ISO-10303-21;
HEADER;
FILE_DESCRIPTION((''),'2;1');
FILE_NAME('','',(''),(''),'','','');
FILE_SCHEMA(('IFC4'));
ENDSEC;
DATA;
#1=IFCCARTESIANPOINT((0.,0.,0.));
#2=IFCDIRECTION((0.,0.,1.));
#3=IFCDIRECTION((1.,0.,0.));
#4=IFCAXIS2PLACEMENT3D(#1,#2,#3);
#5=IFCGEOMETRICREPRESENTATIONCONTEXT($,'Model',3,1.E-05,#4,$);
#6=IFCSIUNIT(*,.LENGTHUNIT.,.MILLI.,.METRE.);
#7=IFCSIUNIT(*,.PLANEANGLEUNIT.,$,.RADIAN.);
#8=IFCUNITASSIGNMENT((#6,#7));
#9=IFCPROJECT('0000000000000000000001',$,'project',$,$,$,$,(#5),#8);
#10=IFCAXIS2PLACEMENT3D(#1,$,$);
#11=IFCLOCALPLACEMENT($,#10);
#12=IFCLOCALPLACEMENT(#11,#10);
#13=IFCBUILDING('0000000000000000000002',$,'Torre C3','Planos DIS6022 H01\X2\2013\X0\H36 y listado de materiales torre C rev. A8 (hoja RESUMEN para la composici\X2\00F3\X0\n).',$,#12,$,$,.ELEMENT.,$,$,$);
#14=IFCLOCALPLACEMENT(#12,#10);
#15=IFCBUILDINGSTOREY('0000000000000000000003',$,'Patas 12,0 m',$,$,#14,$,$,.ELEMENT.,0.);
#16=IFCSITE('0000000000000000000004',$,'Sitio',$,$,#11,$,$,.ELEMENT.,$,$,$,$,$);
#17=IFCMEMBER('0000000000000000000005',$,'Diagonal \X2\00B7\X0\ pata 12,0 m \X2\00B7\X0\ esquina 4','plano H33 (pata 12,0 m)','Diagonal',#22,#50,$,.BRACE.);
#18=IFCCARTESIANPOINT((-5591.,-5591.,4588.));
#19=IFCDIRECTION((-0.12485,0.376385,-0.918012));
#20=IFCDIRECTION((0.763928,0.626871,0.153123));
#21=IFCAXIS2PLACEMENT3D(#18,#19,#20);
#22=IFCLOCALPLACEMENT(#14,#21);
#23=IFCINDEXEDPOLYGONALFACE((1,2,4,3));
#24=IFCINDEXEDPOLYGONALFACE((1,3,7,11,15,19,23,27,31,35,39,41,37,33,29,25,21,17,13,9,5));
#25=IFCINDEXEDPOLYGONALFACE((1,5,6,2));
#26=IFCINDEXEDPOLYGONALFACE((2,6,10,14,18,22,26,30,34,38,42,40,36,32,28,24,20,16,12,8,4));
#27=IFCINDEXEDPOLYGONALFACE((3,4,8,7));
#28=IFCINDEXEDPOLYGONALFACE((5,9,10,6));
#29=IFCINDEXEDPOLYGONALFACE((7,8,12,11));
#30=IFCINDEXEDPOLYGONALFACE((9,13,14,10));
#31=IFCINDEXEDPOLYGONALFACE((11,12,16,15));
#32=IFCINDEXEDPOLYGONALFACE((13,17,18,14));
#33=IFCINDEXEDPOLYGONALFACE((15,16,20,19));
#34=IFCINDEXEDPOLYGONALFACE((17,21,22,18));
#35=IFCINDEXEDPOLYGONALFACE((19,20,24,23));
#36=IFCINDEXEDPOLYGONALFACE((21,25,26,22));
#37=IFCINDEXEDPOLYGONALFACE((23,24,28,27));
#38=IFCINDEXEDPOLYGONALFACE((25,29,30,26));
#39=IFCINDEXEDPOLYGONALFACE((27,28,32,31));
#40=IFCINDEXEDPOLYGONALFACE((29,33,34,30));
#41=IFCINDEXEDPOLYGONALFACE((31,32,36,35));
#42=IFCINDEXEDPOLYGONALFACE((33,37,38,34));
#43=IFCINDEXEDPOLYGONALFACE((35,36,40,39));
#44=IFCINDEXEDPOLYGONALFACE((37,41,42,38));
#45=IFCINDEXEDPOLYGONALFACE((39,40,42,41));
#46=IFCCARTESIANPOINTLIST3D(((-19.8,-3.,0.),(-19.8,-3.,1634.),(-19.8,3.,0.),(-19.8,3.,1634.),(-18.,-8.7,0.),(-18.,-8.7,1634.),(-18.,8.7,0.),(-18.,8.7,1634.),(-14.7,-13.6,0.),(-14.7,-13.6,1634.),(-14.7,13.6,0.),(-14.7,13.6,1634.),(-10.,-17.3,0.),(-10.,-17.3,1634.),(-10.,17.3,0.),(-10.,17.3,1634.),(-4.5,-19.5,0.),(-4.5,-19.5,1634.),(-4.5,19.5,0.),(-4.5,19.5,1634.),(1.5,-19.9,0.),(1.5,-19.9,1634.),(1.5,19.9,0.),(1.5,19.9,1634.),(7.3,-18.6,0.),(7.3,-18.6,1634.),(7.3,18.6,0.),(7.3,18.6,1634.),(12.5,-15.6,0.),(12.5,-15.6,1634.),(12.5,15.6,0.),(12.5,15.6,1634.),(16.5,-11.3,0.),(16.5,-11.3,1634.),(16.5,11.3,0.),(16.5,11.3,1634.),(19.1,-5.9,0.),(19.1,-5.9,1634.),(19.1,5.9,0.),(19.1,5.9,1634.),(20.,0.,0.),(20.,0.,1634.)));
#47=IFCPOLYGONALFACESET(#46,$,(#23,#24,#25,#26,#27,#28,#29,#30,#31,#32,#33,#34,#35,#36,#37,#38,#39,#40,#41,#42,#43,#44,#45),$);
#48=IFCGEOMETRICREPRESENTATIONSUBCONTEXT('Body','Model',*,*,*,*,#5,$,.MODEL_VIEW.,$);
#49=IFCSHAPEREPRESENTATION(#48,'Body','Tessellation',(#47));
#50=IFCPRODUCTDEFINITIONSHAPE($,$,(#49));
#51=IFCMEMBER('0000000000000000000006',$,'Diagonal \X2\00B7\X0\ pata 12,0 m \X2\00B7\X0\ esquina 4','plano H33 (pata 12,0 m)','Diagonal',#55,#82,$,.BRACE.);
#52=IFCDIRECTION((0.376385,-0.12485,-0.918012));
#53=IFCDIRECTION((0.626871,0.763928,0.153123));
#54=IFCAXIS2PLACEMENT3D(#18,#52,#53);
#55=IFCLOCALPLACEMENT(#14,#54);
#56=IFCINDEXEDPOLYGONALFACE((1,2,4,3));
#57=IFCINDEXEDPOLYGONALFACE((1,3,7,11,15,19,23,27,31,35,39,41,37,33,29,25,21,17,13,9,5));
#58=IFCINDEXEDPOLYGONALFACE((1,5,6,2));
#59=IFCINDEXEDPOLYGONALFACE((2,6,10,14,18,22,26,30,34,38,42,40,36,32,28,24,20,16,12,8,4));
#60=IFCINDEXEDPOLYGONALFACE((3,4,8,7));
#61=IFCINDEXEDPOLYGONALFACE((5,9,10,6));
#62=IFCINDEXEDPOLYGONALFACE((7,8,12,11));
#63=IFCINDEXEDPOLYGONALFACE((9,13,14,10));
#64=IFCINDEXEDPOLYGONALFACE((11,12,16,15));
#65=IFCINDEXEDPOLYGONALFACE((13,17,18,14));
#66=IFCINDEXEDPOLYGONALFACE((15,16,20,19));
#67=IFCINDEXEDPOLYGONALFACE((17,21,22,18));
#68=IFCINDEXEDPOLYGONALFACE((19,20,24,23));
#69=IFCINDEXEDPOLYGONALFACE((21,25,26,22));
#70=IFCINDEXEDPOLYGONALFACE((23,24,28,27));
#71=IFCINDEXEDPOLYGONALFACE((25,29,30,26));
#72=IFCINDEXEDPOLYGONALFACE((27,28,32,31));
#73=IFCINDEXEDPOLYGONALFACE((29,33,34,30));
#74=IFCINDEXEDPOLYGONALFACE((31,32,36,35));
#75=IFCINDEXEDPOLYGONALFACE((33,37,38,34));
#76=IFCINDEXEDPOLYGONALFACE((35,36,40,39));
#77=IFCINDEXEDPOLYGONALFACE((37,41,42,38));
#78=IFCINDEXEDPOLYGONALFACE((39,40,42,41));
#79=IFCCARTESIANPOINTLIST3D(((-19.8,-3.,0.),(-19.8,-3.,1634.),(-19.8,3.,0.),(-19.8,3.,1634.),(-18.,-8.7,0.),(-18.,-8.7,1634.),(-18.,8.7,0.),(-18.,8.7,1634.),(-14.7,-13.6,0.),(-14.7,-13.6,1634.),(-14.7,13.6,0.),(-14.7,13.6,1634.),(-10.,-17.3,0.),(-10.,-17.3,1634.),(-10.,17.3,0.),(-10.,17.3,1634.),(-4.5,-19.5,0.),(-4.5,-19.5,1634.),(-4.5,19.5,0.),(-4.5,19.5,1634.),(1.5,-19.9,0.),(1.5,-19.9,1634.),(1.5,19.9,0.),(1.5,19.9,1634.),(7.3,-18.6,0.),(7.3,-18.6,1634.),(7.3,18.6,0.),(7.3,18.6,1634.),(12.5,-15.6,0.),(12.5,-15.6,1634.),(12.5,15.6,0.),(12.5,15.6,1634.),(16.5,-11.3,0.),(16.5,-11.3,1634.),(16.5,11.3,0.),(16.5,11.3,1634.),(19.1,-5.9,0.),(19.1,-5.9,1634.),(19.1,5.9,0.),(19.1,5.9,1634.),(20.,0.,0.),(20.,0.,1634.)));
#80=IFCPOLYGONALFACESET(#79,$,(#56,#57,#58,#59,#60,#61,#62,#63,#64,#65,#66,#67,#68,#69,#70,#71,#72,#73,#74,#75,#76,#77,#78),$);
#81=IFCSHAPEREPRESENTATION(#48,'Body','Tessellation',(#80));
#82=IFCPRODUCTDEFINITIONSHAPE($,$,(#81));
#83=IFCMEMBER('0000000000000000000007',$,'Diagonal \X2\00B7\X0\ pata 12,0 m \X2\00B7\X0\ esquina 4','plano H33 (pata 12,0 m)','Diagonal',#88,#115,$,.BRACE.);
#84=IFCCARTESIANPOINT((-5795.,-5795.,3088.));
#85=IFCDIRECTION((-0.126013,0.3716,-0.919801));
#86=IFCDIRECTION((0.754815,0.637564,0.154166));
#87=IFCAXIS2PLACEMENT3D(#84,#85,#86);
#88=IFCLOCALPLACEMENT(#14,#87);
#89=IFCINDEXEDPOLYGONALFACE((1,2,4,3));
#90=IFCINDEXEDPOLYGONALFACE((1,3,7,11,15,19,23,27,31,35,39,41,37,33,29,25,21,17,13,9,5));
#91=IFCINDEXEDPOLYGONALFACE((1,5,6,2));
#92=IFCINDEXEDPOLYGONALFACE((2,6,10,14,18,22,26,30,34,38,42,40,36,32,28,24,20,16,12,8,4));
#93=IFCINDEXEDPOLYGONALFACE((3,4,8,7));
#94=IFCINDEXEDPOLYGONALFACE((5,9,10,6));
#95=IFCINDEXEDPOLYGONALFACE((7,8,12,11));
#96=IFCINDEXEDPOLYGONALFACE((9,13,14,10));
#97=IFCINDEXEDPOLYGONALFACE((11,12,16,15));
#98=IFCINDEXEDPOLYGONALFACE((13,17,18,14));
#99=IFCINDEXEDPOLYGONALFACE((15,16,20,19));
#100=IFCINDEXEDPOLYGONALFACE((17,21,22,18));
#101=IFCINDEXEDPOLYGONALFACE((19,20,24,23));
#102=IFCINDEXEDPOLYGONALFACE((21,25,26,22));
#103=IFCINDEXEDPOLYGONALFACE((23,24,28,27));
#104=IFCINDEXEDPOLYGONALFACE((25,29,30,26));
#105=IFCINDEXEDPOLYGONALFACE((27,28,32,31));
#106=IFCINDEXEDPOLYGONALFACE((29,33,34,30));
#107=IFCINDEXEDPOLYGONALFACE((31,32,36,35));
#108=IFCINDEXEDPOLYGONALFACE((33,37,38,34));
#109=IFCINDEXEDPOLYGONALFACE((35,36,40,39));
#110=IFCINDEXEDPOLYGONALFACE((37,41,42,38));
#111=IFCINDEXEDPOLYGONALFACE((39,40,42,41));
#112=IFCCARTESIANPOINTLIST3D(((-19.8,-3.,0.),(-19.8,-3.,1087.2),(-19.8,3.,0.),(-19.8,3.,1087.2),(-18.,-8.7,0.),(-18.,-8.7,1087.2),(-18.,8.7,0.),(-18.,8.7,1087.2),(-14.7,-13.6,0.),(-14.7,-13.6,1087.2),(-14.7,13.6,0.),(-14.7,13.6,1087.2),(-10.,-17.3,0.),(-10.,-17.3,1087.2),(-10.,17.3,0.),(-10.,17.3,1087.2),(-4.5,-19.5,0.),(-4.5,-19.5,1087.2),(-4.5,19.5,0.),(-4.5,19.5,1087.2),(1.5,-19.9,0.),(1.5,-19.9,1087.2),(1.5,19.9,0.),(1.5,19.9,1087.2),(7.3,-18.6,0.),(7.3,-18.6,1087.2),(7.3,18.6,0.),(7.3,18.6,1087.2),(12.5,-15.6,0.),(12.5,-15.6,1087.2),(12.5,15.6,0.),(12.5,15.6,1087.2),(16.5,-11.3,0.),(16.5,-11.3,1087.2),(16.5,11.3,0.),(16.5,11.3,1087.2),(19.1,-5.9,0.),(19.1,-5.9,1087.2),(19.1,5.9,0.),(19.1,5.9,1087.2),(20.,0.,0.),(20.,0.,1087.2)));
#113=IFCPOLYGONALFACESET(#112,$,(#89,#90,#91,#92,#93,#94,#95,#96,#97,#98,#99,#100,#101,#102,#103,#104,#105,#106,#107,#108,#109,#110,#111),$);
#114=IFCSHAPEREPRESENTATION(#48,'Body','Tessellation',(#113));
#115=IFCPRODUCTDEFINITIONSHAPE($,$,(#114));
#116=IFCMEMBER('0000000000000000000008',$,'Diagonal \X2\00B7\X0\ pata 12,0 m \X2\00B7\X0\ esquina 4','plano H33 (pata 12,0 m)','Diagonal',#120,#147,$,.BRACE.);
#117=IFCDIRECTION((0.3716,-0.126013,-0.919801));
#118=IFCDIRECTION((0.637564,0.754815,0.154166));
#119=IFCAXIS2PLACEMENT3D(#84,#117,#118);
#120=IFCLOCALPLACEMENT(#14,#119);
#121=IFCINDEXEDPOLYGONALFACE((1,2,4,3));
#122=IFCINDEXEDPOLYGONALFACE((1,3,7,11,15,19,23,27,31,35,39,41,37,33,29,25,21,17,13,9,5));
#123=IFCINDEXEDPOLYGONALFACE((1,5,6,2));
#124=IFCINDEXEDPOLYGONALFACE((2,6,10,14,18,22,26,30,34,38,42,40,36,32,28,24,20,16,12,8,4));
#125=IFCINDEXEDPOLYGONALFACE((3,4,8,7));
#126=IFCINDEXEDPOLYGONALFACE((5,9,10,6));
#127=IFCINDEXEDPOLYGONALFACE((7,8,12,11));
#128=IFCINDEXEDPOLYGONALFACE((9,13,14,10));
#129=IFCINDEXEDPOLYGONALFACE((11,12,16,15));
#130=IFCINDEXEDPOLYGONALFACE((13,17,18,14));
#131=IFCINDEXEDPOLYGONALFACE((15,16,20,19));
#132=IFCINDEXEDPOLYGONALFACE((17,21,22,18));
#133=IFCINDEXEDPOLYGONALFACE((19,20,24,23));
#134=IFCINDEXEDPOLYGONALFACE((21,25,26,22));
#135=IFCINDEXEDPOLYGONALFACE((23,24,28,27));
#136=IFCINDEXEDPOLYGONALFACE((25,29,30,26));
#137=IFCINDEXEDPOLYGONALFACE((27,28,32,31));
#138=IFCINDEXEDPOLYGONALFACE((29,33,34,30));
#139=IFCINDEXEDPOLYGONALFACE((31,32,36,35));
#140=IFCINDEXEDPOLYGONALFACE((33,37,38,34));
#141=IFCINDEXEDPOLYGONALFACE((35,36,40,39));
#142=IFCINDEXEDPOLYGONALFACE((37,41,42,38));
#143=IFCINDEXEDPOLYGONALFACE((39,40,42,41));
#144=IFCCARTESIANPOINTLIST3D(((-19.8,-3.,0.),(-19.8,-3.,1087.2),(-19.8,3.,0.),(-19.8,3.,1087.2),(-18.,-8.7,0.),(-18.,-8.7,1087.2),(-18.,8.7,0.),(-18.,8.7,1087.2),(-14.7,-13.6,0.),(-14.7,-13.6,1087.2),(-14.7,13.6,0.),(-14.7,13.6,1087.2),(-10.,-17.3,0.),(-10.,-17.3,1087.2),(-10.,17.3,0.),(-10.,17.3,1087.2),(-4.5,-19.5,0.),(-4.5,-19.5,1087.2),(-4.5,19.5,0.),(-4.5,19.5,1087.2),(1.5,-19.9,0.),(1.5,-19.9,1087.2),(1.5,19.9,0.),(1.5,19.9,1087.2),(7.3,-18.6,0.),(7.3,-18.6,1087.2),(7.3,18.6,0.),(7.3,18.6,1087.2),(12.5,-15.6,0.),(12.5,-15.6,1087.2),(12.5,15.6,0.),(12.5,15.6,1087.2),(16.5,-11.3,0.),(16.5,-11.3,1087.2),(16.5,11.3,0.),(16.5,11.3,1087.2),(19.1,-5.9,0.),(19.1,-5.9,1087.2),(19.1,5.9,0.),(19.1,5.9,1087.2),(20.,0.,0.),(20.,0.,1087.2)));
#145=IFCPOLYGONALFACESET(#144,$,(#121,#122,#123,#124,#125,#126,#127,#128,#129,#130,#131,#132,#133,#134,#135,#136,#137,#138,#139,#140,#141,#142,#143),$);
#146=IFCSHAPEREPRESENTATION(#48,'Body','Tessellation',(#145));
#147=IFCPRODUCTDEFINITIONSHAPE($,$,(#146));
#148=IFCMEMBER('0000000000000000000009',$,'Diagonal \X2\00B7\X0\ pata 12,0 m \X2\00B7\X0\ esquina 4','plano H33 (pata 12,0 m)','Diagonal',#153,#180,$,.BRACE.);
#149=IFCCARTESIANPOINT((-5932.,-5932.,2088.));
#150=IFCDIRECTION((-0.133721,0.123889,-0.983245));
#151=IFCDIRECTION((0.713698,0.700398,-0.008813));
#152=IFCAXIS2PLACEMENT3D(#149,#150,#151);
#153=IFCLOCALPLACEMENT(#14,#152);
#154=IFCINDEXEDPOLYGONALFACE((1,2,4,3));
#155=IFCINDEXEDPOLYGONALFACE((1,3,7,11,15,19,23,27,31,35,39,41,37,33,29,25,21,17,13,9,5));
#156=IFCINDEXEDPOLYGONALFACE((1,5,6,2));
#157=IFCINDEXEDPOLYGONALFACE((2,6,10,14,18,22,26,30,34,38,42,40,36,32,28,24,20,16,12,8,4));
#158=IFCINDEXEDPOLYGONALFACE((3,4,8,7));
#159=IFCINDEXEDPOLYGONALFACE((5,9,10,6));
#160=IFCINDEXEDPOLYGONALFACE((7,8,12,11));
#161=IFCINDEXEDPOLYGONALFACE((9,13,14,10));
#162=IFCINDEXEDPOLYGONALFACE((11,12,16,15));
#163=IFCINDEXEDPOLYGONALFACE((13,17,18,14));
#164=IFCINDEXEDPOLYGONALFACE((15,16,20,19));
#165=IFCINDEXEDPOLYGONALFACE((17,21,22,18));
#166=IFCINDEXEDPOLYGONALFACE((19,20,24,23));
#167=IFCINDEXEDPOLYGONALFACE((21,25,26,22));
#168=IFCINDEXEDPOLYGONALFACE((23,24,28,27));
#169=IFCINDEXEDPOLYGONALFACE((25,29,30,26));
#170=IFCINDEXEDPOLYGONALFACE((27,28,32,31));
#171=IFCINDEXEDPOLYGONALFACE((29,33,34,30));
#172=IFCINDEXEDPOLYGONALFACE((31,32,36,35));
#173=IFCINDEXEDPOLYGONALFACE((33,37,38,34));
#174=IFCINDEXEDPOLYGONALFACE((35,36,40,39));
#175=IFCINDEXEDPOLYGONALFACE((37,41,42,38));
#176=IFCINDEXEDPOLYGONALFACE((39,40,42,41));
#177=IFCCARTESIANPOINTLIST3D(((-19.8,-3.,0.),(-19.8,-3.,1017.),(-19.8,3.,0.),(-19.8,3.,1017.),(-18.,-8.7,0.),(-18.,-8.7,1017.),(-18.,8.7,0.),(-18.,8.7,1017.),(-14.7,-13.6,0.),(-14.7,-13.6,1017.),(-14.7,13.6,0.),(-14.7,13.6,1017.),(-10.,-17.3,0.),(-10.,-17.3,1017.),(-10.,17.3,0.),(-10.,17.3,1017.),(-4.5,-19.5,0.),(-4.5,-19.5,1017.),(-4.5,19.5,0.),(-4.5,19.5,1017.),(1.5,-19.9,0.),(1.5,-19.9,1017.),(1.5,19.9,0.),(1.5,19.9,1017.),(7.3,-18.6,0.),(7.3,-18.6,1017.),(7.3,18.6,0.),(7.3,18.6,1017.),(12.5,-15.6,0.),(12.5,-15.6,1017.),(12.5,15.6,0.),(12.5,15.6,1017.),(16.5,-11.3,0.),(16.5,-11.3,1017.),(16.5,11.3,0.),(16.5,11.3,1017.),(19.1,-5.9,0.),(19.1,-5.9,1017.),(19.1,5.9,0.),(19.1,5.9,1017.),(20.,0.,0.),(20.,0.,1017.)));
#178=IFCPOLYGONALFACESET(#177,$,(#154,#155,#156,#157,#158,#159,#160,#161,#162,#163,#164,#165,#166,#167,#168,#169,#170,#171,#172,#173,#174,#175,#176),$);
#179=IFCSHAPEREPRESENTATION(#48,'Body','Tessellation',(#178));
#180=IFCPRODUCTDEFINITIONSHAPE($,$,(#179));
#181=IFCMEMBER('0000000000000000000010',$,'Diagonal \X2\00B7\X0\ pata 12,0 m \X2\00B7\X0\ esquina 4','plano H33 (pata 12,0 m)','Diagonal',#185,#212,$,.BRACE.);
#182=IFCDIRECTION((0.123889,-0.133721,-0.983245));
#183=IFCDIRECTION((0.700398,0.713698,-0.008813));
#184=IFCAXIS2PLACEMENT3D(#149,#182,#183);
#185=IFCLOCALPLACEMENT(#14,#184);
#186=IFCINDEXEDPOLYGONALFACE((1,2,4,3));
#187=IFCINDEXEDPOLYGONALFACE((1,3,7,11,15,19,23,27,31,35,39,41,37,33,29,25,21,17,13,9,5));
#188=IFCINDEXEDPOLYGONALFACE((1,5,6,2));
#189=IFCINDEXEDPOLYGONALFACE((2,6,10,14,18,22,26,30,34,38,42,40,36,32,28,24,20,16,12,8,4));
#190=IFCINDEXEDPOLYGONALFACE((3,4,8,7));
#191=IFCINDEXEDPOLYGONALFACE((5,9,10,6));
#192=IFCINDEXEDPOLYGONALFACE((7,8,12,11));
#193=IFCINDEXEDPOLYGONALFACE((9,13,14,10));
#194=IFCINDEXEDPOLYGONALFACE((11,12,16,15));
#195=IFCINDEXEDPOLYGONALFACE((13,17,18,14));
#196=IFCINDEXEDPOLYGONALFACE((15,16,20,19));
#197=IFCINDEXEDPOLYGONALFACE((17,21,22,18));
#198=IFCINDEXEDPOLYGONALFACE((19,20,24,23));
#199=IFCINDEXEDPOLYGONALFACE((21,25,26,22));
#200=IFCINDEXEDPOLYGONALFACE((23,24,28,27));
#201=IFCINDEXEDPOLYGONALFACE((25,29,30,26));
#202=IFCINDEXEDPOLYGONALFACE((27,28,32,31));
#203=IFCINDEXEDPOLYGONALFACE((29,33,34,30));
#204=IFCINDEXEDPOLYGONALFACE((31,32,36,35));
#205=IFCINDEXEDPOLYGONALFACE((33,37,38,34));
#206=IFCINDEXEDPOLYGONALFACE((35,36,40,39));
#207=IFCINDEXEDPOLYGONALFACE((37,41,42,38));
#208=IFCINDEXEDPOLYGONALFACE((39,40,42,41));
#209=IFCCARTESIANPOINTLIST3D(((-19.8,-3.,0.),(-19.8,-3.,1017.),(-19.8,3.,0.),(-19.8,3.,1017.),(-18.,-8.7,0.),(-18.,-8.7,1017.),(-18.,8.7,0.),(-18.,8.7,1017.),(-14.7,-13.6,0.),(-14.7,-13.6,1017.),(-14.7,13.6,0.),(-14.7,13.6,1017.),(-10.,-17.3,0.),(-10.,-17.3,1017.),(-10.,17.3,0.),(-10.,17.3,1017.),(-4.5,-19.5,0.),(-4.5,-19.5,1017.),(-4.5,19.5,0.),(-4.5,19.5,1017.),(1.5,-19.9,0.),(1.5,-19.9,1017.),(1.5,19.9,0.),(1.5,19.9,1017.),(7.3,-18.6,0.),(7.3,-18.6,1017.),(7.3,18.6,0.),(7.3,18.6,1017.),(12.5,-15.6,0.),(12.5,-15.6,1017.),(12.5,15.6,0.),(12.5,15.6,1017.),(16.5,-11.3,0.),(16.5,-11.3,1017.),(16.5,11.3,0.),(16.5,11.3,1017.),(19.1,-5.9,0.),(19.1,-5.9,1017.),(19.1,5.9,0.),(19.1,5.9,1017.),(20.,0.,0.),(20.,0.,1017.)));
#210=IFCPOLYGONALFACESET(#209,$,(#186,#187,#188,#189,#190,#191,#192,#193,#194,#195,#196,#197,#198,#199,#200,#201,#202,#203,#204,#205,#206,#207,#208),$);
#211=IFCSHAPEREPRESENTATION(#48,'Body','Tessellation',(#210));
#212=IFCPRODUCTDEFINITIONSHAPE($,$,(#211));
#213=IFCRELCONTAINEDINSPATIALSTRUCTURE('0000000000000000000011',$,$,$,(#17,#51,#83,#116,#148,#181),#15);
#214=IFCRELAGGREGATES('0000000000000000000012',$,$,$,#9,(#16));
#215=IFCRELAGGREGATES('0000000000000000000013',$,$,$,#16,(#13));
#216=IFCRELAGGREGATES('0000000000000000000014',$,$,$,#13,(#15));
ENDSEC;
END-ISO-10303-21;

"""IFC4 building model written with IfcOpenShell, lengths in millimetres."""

from ifc_helpers import new_model, si_unit, frame, origin, origin_with_axes, place, context, subcontext, project, spatial, circle, extrude, element, save


model = new_model("IFC4")

# Units and contexts
model_context = context("Model", 3, precision=1e-05, world=origin_with_axes())
body_context = subcontext(model_context, "Body", "Model", "MODEL_VIEW")
ifc_project = project(units=[si_unit("LENGTHUNIT", "METRE", prefix="MILLI"), si_unit("PLANEANGLEUNIT", "RADIAN")], contexts=[model_context])

# Site, building, storey
site_placement = place(None, origin())
site = spatial("IfcSite", under=ifc_project, at=site_placement, Name="Sitio", CompositionType="ELEMENT")
building_placement = place(site_placement, origin())
building = spatial("IfcBuilding", under=site, at=building_placement, Name="Torre C3", Description="Planos DIS6022 H01–H36 y listado de materiales torre C rev. A8 (hoja RESUMEN para la composición).", CompositionType="ELEMENT")
storey_placement = place(building_placement, origin())
storey = spatial("IfcBuildingStorey", under=building, at=storey_placement, Name="Patas 12,0 m", CompositionType="ELEMENT", Elevation=0.0)

# Members
for number, where, z_axis, x_axis, name in (
    (1, (-5591.0, -5591.0, 4588.0), (-0.12485, 0.376385, -0.918012), (0.763928, 0.626871, 0.153123), "Diagonal · pata 12,0 m · esquina 4"),
    (2, (-5591.0, -5591.0, 4588.0), (0.376385, -0.12485, -0.918012), (0.626871, 0.763928, 0.153123), "Diagonal · pata 12,0 m · esquina 4"),
):
    element("IfcMember", number, at=place(storey_placement, frame(where, z_axis=z_axis, x_axis=x_axis)), inside=storey, Name=name, Description="plano H33 (pata 12,0 m)", ObjectType="Diagonal", PredefinedType="BRACE", context=body_context, shape_type="SweptSolid", body=[
        extrude(circle(Radius=20.0), None, (0.0, 0.0, 1.0), 1634.0),
    ])
for number, where, z_axis, x_axis, name in (
    (3, (-5795.0, -5795.0, 3088.0), (-0.126013, 0.3716, -0.919801), (0.754815, 0.637564, 0.154166), "Diagonal · pata 12,0 m · esquina 4"),
    (4, (-5795.0, -5795.0, 3088.0), (0.3716, -0.126013, -0.919801), (0.637564, 0.754815, 0.154166), "Diagonal · pata 12,0 m · esquina 4"),
):
    element("IfcMember", number, at=place(storey_placement, frame(where, z_axis=z_axis, x_axis=x_axis)), inside=storey, Name=name, Description="plano H33 (pata 12,0 m)", ObjectType="Diagonal", PredefinedType="BRACE", context=body_context, shape_type="SweptSolid", body=[
        extrude(circle(Radius=20.0), None, (0.0, 0.0, 1.0), 1087.2),
    ])
for number, where, z_axis, x_axis, name in (
    (5, (-5932.0, -5932.0, 2088.0), (-0.133721, 0.123889, -0.983245), (0.713698, 0.700398, -0.008813), "Diagonal · pata 12,0 m · esquina 4"),
    (6, (-5932.0, -5932.0, 2088.0), (0.123889, -0.133721, -0.983245), (0.700398, 0.713698, -0.008813), "Diagonal · pata 12,0 m · esquina 4"),
):
    element("IfcMember", number, at=place(storey_placement, frame(where, z_axis=z_axis, x_axis=x_axis)), inside=storey, Name=name, Description="plano H33 (pata 12,0 m)", ObjectType="Diagonal", PredefinedType="BRACE", context=body_context, shape_type="SweptSolid", body=[
        extrude(circle(Radius=20.0), None, (0.0, 0.0, 1.0), 1017.0),
    ])

save(model, "model.ifc")
